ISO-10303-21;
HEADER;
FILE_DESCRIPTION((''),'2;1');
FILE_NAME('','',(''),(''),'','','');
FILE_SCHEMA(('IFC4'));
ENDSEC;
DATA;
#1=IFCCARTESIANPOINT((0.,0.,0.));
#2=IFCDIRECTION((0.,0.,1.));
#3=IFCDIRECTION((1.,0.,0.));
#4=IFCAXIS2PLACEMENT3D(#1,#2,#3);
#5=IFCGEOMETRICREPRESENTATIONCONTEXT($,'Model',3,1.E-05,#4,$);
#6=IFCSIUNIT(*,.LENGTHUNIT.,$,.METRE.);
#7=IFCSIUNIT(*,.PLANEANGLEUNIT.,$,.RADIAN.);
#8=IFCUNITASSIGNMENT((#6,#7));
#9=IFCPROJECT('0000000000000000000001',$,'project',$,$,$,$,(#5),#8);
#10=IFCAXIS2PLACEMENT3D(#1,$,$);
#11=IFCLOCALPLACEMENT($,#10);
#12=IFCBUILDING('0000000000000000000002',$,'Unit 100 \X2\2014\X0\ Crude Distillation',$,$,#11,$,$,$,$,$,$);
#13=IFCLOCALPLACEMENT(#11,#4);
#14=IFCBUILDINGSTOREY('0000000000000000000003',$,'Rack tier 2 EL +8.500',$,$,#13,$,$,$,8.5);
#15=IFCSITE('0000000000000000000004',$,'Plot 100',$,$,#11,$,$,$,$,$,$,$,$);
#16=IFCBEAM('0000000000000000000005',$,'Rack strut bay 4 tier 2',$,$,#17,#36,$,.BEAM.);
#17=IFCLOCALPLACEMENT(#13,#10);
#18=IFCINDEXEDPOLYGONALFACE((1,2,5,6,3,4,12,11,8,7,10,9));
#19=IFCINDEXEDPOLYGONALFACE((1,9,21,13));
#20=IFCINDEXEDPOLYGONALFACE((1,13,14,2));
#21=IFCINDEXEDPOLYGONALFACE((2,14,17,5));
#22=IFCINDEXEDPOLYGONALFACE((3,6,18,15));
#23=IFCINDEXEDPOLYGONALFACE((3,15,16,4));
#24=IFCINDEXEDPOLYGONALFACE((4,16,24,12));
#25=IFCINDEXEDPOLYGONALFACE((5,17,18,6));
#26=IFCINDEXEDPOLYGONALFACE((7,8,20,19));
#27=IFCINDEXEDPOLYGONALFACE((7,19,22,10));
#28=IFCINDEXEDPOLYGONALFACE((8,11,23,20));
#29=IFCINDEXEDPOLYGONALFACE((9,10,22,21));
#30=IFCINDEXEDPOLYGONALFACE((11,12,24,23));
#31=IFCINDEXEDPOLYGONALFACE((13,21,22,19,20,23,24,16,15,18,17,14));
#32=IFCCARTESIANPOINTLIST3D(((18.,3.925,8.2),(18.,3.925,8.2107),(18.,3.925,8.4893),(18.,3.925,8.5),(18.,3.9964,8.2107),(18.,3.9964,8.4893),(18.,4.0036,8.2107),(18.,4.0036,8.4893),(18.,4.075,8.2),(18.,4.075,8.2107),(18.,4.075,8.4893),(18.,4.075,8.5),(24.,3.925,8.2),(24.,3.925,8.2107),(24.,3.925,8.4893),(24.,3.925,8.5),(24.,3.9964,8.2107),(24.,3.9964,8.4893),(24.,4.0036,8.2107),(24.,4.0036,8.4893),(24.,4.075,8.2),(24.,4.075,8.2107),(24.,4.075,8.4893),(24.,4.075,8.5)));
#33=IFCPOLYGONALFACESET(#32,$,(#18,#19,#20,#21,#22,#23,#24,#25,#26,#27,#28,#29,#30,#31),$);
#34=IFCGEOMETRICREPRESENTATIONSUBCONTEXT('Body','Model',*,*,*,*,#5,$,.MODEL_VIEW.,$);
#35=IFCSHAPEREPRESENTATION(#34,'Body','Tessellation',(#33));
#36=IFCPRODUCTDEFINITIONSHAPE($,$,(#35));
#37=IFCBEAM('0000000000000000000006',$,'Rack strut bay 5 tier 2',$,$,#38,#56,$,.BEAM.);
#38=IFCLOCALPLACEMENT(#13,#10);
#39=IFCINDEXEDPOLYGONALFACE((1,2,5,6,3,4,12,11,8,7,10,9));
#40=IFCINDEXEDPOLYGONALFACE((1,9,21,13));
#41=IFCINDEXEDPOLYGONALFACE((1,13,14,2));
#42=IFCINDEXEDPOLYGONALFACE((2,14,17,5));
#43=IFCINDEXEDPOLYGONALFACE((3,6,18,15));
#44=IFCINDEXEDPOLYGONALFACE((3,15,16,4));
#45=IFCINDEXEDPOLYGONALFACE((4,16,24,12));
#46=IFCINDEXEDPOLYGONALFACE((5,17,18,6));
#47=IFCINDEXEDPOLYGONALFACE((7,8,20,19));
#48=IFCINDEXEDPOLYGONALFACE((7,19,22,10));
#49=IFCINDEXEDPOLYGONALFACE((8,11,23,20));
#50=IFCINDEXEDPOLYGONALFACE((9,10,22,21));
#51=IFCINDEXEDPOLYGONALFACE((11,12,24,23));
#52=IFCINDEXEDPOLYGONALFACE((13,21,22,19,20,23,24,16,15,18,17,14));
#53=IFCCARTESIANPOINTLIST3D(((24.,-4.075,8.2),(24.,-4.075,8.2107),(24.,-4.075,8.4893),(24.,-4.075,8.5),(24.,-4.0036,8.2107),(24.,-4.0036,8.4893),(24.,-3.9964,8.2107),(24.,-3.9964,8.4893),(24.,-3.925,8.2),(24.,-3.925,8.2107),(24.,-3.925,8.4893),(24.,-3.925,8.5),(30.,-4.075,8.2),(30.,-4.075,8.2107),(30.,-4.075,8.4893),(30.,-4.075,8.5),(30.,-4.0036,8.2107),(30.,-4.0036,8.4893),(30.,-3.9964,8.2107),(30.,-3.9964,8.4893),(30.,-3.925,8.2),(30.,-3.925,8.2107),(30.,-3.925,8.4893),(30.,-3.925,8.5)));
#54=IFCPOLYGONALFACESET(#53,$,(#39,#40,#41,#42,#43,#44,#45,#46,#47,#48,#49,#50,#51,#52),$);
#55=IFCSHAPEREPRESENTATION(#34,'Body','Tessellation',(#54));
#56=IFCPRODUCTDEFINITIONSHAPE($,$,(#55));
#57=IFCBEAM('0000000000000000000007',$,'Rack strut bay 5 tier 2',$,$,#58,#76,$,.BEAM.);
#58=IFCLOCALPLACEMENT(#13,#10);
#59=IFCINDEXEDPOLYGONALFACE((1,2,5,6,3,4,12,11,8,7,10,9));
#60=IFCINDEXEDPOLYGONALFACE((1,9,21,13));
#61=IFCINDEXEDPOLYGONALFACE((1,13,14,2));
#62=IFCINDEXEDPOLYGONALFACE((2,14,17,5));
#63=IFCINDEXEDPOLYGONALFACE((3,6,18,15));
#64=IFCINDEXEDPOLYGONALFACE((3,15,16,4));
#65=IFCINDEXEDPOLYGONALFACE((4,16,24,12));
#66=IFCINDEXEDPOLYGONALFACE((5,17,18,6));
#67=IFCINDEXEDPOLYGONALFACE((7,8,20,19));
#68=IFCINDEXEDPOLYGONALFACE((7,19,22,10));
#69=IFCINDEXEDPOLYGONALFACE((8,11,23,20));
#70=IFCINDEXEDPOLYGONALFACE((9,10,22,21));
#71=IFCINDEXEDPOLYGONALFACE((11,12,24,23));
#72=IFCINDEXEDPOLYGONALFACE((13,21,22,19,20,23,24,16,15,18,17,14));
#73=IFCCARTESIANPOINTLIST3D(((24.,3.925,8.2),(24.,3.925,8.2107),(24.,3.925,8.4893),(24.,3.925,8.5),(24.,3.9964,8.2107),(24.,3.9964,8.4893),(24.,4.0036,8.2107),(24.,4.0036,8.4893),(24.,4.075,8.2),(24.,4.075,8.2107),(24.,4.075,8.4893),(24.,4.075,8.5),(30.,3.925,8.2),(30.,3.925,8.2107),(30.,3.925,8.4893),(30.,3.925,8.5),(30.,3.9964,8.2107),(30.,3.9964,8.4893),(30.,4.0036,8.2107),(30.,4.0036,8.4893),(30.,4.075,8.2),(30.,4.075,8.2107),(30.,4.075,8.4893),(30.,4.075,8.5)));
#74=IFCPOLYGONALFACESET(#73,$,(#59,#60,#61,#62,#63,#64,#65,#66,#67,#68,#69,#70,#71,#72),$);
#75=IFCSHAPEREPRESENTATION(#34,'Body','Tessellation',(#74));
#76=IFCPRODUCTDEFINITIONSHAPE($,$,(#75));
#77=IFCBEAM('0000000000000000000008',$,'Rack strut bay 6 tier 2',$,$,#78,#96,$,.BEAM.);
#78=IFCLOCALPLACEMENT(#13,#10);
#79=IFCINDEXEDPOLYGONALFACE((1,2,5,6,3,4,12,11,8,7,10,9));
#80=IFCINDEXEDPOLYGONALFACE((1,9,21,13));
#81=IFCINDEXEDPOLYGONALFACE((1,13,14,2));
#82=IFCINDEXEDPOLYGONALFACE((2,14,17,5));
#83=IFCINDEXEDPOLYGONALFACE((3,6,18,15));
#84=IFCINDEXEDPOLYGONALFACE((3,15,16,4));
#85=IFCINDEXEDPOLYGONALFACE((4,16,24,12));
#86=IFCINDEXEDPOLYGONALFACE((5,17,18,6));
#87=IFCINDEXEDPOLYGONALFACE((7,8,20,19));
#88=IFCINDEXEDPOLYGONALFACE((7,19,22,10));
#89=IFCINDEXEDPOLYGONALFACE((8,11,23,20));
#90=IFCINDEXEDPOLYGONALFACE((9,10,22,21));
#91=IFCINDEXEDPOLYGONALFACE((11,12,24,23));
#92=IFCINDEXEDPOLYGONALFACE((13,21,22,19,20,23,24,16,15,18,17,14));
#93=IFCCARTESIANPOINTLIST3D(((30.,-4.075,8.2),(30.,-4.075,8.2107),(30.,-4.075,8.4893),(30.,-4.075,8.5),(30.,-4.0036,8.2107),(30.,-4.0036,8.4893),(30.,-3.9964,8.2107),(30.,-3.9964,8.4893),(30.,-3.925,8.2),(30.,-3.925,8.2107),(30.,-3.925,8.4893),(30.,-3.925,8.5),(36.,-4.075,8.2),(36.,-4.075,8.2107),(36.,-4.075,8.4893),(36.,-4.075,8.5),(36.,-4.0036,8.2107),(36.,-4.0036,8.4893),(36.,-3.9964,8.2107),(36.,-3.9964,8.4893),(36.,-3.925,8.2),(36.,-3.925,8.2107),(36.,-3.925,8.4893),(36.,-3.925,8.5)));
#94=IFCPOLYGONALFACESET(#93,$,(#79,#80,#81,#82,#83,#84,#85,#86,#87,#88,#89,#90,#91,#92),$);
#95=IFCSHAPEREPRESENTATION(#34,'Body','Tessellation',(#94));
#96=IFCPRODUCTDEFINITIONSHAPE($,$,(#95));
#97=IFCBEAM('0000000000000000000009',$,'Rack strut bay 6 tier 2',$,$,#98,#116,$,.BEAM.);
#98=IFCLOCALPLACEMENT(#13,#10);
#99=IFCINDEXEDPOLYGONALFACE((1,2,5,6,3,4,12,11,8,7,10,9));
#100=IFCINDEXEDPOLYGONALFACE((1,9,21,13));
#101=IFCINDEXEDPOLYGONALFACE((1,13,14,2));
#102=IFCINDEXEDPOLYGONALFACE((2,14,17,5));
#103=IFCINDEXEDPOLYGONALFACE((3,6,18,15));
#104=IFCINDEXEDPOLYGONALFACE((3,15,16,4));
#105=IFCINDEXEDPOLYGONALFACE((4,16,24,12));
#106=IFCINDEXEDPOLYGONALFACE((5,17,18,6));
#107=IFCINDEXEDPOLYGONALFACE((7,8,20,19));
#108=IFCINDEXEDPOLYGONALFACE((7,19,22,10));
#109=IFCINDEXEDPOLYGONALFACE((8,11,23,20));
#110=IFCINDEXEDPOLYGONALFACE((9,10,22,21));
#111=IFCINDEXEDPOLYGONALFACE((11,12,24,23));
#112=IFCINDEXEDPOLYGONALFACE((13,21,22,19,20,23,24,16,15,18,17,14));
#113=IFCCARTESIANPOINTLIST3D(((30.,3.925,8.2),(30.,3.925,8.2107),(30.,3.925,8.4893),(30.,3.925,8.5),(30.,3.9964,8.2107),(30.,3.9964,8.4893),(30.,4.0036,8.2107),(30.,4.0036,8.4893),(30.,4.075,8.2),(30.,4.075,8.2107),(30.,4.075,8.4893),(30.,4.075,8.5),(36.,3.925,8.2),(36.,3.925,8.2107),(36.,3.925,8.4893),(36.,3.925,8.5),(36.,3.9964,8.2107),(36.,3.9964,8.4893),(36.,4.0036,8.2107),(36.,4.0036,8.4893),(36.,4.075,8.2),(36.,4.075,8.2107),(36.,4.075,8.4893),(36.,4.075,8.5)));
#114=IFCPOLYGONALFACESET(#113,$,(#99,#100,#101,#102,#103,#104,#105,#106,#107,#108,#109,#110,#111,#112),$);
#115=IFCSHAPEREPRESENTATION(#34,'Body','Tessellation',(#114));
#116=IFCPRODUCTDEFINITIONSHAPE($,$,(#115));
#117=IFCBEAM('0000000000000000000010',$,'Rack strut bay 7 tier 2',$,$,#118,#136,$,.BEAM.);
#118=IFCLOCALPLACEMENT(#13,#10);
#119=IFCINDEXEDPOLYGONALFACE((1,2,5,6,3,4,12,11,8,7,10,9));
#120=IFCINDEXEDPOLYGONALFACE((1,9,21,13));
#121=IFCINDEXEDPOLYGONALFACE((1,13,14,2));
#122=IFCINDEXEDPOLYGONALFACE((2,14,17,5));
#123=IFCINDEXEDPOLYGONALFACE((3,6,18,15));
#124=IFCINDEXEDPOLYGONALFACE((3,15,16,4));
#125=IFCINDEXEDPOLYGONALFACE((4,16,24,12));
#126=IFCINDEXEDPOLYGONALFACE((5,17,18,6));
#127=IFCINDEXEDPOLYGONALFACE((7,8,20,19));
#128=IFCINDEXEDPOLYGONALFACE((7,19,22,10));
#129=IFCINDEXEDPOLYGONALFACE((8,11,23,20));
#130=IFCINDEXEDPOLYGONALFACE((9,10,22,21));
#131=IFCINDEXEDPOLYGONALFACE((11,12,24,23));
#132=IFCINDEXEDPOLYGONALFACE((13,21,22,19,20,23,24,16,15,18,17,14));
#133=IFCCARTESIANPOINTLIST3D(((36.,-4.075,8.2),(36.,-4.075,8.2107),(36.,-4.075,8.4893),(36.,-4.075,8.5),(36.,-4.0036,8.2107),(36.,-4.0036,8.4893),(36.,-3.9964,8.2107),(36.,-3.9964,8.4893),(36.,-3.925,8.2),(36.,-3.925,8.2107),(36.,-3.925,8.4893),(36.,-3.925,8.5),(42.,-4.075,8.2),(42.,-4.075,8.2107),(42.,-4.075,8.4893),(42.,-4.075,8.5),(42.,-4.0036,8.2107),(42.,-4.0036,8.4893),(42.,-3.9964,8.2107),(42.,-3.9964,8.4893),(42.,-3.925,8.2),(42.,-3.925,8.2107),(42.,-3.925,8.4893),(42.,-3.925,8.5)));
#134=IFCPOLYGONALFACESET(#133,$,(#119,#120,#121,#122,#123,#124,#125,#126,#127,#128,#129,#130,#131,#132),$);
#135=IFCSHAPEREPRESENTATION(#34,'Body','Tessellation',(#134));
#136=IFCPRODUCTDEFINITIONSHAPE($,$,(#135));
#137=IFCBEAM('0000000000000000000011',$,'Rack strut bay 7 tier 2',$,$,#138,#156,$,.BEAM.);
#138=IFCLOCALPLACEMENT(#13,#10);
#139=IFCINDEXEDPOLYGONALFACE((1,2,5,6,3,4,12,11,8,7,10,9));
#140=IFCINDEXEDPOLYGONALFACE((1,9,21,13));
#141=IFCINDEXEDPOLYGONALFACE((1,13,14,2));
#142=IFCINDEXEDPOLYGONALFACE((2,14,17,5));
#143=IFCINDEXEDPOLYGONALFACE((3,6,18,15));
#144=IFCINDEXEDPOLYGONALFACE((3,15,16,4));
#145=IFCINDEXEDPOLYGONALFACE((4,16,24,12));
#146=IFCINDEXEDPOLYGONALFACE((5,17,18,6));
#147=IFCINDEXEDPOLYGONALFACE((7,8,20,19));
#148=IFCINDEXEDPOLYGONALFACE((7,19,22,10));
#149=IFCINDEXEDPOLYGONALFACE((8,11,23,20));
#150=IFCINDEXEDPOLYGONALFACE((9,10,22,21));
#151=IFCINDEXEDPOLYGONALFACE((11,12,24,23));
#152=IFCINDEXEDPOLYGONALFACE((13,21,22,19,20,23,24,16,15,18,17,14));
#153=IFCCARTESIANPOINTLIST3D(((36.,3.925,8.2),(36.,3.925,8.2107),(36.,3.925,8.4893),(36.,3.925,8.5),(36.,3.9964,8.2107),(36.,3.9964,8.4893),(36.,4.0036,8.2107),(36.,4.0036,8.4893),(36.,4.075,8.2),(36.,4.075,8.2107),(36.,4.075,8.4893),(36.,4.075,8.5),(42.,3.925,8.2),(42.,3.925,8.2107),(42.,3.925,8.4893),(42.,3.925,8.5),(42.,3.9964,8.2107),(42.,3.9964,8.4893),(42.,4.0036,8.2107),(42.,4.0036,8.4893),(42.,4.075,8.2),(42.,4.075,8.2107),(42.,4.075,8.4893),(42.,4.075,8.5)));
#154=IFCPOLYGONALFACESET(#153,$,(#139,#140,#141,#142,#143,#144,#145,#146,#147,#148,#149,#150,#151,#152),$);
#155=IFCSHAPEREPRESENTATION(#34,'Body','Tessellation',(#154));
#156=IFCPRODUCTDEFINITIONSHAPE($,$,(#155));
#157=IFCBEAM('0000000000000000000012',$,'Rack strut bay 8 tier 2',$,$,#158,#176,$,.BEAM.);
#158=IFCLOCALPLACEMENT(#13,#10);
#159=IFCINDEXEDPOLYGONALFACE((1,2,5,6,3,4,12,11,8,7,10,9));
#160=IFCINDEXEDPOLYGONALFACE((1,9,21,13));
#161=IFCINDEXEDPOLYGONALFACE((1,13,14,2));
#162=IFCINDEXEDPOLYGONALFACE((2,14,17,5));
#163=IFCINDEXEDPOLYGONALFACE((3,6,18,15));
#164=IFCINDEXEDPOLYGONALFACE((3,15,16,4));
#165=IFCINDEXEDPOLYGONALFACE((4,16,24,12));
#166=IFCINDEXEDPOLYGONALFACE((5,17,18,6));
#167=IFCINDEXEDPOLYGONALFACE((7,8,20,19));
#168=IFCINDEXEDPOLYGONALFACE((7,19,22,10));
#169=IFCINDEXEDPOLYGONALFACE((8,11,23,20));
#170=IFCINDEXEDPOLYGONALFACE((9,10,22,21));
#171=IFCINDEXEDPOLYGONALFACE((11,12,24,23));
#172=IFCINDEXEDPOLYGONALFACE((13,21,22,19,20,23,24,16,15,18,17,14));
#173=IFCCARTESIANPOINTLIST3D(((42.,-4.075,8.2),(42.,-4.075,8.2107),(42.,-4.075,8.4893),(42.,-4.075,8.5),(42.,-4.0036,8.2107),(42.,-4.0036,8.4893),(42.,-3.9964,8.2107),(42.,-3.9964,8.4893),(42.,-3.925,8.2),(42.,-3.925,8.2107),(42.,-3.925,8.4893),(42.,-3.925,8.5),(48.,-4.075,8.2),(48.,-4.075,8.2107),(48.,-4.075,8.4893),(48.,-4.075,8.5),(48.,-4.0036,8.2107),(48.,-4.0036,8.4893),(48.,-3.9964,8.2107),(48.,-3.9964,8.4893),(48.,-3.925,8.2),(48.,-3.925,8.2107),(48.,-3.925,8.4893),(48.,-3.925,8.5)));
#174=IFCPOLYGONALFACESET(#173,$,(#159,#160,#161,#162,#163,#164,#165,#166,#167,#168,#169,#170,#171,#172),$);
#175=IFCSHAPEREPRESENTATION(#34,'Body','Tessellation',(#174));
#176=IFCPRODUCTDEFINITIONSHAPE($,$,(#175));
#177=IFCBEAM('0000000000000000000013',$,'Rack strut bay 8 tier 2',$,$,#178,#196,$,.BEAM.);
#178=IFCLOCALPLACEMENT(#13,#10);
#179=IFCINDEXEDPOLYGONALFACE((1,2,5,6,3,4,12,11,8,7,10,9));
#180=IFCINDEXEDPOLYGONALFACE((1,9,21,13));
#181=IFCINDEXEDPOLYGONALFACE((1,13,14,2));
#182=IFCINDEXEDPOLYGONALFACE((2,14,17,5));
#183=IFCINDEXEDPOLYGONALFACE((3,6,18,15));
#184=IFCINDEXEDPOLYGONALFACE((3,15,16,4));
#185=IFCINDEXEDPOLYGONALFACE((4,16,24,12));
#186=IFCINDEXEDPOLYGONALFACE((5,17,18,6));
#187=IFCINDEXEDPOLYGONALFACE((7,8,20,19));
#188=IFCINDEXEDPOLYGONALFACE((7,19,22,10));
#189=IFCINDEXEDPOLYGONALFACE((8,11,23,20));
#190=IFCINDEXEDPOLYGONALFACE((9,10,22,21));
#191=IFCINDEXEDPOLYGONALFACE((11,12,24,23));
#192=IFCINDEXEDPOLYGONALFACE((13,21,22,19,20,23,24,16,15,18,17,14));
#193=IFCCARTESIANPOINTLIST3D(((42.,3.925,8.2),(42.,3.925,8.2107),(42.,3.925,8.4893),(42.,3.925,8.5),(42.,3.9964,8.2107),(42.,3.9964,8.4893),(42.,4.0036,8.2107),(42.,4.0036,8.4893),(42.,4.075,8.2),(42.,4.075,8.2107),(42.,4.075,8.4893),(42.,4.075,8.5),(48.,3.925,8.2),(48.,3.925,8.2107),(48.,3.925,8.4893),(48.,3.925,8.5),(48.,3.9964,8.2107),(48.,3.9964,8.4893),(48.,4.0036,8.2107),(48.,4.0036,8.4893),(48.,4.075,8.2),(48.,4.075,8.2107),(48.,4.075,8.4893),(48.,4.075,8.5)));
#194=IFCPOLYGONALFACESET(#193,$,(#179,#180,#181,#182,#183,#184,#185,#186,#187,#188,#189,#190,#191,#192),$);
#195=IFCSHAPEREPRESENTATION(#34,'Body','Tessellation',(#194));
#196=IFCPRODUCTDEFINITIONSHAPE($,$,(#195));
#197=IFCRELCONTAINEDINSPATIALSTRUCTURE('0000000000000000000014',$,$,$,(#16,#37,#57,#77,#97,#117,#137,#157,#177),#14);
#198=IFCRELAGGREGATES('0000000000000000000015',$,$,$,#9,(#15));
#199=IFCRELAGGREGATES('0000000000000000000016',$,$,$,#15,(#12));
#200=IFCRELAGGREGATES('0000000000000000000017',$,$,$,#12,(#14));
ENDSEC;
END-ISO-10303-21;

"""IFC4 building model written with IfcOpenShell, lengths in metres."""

from ifc_helpers import new_model, si_unit, frame, origin, origin_with_axes, origin_2d, place, context, subcontext, project, spatial, i_section, extrude, element, save


model = new_model("IFC4")

# Units and contexts
model_context = context("Model", 3, precision=1e-05, world=origin_with_axes())
body_context = subcontext(model_context, "Body", "Model", "MODEL_VIEW")
ifc_project = project(units=[si_unit("LENGTHUNIT", "METRE"), si_unit("PLANEANGLEUNIT", "RADIAN")], contexts=[model_context])

# Site, building, storey
placement = place(None, origin())
site = spatial("IfcSite", under=ifc_project, at=placement, Name="Plot 100")
building = spatial("IfcBuilding", under=site, at=placement, Name="Unit 100 — Crude Distillation")
storey_placement = place(placement, origin_with_axes())
storey = spatial("IfcBuildingStorey", under=building, at=storey_placement, Name="Rack tier 2 EL +8.500", Elevation=8.5)

# Beams
beam_1_placement = place(storey_placement, origin_with_axes())
element("IfcBeam", 1, at=beam_1_placement, inside=storey, Name="Rack strut bay 4 tier 2", PredefinedType="BEAM", context=body_context, shape_type="SweptSolid", body=[
    extrude(i_section(OverallWidth=0.15, OverallDepth=0.3, WebThickness=0.0071, FlangeThickness=0.0107, at=origin_2d()), frame((18.0, 4.0, 8.35), z_axis=(1.0, 0.0, 0.0), x_axis=(0.0, 1.0, 0.0)), (0.0, 0.0, 1.0), 6.0),
])
beam_2_placement = place(storey_placement, origin_with_axes())
element("IfcBeam", 2, at=beam_2_placement, inside=storey, Name="Rack strut bay 5 tier 2", PredefinedType="BEAM", context=body_context, shape_type="SweptSolid", body=[
    extrude(i_section(OverallWidth=0.15, OverallDepth=0.3, WebThickness=0.0071, FlangeThickness=0.0107, at=origin_2d()), frame((24.0, -4.0, 8.35), z_axis=(1.0, 0.0, 0.0), x_axis=(0.0, 1.0, 0.0)), (0.0, 0.0, 1.0), 6.0),
])
beam_3_placement = place(storey_placement, origin_with_axes())
element("IfcBeam", 3, at=beam_3_placement, inside=storey, Name="Rack strut bay 5 tier 2", PredefinedType="BEAM", context=body_context, shape_type="SweptSolid", body=[
    extrude(i_section(OverallWidth=0.15, OverallDepth=0.3, WebThickness=0.0071, FlangeThickness=0.0107, at=origin_2d()), frame((24.0, 4.0, 8.35), z_axis=(1.0, 0.0, 0.0), x_axis=(0.0, 1.0, 0.0)), (0.0, 0.0, 1.0), 6.0),
])
beam_4_placement = place(storey_placement, origin_with_axes())
element("IfcBeam", 4, at=beam_4_placement, inside=storey, Name="Rack strut bay 6 tier 2", PredefinedType="BEAM", context=body_context, shape_type="SweptSolid", body=[
    extrude(i_section(OverallWidth=0.15, OverallDepth=0.3, WebThickness=0.0071, FlangeThickness=0.0107, at=origin_2d()), frame((30.0, -4.0, 8.35), z_axis=(1.0, 0.0, 0.0), x_axis=(0.0, 1.0, 0.0)), (0.0, 0.0, 1.0), 6.0),
])
beam_5_placement = place(storey_placement, origin_with_axes())
element("IfcBeam", 5, at=beam_5_placement, inside=storey, Name="Rack strut bay 6 tier 2", PredefinedType="BEAM", context=body_context, shape_type="SweptSolid", body=[
    extrude(i_section(OverallWidth=0.15, OverallDepth=0.3, WebThickness=0.0071, FlangeThickness=0.0107, at=origin_2d()), frame((30.0, 4.0, 8.35), z_axis=(1.0, 0.0, 0.0), x_axis=(0.0, 1.0, 0.0)), (0.0, 0.0, 1.0), 6.0),
])
beam_6_placement = place(storey_placement, origin_with_axes())
element("IfcBeam", 6, at=beam_6_placement, inside=storey, Name="Rack strut bay 7 tier 2", PredefinedType="BEAM", context=body_context, shape_type="SweptSolid", body=[
    extrude(i_section(OverallWidth=0.15, OverallDepth=0.3, WebThickness=0.0071, FlangeThickness=0.0107, at=origin_2d()), frame((36.0, -4.0, 8.35), z_axis=(1.0, 0.0, 0.0), x_axis=(0.0, 1.0, 0.0)), (0.0, 0.0, 1.0), 6.0),
])
beam_7_placement = place(storey_placement, origin_with_axes())
element("IfcBeam", 7, at=beam_7_placement, inside=storey, Name="Rack strut bay 7 tier 2", PredefinedType="BEAM", context=body_context, shape_type="SweptSolid", body=[
    extrude(i_section(OverallWidth=0.15, OverallDepth=0.3, WebThickness=0.0071, FlangeThickness=0.0107, at=origin_2d()), frame((36.0, 4.0, 8.35), z_axis=(1.0, 0.0, 0.0), x_axis=(0.0, 1.0, 0.0)), (0.0, 0.0, 1.0), 6.0),
])
beam_8_placement = place(storey_placement, origin_with_axes())
element("IfcBeam", 8, at=beam_8_placement, inside=storey, Name="Rack strut bay 8 tier 2", PredefinedType="BEAM", context=body_context, shape_type="SweptSolid", body=[
    extrude(i_section(OverallWidth=0.15, OverallDepth=0.3, WebThickness=0.0071, FlangeThickness=0.0107, at=origin_2d()), frame((42.0, -4.0, 8.35), z_axis=(1.0, 0.0, 0.0), x_axis=(0.0, 1.0, 0.0)), (0.0, 0.0, 1.0), 6.0),
])
beam_9_placement = place(storey_placement, origin_with_axes())
element("IfcBeam", 9, at=beam_9_placement, inside=storey, Name="Rack strut bay 8 tier 2", PredefinedType="BEAM", context=body_context, shape_type="SweptSolid", body=[
    extrude(i_section(OverallWidth=0.15, OverallDepth=0.3, WebThickness=0.0071, FlangeThickness=0.0107, at=origin_2d()), frame((42.0, 4.0, 8.35), z_axis=(1.0, 0.0, 0.0), x_axis=(0.0, 1.0, 0.0)), (0.0, 0.0, 1.0), 6.0),
])

save(model, "model.ifc")
